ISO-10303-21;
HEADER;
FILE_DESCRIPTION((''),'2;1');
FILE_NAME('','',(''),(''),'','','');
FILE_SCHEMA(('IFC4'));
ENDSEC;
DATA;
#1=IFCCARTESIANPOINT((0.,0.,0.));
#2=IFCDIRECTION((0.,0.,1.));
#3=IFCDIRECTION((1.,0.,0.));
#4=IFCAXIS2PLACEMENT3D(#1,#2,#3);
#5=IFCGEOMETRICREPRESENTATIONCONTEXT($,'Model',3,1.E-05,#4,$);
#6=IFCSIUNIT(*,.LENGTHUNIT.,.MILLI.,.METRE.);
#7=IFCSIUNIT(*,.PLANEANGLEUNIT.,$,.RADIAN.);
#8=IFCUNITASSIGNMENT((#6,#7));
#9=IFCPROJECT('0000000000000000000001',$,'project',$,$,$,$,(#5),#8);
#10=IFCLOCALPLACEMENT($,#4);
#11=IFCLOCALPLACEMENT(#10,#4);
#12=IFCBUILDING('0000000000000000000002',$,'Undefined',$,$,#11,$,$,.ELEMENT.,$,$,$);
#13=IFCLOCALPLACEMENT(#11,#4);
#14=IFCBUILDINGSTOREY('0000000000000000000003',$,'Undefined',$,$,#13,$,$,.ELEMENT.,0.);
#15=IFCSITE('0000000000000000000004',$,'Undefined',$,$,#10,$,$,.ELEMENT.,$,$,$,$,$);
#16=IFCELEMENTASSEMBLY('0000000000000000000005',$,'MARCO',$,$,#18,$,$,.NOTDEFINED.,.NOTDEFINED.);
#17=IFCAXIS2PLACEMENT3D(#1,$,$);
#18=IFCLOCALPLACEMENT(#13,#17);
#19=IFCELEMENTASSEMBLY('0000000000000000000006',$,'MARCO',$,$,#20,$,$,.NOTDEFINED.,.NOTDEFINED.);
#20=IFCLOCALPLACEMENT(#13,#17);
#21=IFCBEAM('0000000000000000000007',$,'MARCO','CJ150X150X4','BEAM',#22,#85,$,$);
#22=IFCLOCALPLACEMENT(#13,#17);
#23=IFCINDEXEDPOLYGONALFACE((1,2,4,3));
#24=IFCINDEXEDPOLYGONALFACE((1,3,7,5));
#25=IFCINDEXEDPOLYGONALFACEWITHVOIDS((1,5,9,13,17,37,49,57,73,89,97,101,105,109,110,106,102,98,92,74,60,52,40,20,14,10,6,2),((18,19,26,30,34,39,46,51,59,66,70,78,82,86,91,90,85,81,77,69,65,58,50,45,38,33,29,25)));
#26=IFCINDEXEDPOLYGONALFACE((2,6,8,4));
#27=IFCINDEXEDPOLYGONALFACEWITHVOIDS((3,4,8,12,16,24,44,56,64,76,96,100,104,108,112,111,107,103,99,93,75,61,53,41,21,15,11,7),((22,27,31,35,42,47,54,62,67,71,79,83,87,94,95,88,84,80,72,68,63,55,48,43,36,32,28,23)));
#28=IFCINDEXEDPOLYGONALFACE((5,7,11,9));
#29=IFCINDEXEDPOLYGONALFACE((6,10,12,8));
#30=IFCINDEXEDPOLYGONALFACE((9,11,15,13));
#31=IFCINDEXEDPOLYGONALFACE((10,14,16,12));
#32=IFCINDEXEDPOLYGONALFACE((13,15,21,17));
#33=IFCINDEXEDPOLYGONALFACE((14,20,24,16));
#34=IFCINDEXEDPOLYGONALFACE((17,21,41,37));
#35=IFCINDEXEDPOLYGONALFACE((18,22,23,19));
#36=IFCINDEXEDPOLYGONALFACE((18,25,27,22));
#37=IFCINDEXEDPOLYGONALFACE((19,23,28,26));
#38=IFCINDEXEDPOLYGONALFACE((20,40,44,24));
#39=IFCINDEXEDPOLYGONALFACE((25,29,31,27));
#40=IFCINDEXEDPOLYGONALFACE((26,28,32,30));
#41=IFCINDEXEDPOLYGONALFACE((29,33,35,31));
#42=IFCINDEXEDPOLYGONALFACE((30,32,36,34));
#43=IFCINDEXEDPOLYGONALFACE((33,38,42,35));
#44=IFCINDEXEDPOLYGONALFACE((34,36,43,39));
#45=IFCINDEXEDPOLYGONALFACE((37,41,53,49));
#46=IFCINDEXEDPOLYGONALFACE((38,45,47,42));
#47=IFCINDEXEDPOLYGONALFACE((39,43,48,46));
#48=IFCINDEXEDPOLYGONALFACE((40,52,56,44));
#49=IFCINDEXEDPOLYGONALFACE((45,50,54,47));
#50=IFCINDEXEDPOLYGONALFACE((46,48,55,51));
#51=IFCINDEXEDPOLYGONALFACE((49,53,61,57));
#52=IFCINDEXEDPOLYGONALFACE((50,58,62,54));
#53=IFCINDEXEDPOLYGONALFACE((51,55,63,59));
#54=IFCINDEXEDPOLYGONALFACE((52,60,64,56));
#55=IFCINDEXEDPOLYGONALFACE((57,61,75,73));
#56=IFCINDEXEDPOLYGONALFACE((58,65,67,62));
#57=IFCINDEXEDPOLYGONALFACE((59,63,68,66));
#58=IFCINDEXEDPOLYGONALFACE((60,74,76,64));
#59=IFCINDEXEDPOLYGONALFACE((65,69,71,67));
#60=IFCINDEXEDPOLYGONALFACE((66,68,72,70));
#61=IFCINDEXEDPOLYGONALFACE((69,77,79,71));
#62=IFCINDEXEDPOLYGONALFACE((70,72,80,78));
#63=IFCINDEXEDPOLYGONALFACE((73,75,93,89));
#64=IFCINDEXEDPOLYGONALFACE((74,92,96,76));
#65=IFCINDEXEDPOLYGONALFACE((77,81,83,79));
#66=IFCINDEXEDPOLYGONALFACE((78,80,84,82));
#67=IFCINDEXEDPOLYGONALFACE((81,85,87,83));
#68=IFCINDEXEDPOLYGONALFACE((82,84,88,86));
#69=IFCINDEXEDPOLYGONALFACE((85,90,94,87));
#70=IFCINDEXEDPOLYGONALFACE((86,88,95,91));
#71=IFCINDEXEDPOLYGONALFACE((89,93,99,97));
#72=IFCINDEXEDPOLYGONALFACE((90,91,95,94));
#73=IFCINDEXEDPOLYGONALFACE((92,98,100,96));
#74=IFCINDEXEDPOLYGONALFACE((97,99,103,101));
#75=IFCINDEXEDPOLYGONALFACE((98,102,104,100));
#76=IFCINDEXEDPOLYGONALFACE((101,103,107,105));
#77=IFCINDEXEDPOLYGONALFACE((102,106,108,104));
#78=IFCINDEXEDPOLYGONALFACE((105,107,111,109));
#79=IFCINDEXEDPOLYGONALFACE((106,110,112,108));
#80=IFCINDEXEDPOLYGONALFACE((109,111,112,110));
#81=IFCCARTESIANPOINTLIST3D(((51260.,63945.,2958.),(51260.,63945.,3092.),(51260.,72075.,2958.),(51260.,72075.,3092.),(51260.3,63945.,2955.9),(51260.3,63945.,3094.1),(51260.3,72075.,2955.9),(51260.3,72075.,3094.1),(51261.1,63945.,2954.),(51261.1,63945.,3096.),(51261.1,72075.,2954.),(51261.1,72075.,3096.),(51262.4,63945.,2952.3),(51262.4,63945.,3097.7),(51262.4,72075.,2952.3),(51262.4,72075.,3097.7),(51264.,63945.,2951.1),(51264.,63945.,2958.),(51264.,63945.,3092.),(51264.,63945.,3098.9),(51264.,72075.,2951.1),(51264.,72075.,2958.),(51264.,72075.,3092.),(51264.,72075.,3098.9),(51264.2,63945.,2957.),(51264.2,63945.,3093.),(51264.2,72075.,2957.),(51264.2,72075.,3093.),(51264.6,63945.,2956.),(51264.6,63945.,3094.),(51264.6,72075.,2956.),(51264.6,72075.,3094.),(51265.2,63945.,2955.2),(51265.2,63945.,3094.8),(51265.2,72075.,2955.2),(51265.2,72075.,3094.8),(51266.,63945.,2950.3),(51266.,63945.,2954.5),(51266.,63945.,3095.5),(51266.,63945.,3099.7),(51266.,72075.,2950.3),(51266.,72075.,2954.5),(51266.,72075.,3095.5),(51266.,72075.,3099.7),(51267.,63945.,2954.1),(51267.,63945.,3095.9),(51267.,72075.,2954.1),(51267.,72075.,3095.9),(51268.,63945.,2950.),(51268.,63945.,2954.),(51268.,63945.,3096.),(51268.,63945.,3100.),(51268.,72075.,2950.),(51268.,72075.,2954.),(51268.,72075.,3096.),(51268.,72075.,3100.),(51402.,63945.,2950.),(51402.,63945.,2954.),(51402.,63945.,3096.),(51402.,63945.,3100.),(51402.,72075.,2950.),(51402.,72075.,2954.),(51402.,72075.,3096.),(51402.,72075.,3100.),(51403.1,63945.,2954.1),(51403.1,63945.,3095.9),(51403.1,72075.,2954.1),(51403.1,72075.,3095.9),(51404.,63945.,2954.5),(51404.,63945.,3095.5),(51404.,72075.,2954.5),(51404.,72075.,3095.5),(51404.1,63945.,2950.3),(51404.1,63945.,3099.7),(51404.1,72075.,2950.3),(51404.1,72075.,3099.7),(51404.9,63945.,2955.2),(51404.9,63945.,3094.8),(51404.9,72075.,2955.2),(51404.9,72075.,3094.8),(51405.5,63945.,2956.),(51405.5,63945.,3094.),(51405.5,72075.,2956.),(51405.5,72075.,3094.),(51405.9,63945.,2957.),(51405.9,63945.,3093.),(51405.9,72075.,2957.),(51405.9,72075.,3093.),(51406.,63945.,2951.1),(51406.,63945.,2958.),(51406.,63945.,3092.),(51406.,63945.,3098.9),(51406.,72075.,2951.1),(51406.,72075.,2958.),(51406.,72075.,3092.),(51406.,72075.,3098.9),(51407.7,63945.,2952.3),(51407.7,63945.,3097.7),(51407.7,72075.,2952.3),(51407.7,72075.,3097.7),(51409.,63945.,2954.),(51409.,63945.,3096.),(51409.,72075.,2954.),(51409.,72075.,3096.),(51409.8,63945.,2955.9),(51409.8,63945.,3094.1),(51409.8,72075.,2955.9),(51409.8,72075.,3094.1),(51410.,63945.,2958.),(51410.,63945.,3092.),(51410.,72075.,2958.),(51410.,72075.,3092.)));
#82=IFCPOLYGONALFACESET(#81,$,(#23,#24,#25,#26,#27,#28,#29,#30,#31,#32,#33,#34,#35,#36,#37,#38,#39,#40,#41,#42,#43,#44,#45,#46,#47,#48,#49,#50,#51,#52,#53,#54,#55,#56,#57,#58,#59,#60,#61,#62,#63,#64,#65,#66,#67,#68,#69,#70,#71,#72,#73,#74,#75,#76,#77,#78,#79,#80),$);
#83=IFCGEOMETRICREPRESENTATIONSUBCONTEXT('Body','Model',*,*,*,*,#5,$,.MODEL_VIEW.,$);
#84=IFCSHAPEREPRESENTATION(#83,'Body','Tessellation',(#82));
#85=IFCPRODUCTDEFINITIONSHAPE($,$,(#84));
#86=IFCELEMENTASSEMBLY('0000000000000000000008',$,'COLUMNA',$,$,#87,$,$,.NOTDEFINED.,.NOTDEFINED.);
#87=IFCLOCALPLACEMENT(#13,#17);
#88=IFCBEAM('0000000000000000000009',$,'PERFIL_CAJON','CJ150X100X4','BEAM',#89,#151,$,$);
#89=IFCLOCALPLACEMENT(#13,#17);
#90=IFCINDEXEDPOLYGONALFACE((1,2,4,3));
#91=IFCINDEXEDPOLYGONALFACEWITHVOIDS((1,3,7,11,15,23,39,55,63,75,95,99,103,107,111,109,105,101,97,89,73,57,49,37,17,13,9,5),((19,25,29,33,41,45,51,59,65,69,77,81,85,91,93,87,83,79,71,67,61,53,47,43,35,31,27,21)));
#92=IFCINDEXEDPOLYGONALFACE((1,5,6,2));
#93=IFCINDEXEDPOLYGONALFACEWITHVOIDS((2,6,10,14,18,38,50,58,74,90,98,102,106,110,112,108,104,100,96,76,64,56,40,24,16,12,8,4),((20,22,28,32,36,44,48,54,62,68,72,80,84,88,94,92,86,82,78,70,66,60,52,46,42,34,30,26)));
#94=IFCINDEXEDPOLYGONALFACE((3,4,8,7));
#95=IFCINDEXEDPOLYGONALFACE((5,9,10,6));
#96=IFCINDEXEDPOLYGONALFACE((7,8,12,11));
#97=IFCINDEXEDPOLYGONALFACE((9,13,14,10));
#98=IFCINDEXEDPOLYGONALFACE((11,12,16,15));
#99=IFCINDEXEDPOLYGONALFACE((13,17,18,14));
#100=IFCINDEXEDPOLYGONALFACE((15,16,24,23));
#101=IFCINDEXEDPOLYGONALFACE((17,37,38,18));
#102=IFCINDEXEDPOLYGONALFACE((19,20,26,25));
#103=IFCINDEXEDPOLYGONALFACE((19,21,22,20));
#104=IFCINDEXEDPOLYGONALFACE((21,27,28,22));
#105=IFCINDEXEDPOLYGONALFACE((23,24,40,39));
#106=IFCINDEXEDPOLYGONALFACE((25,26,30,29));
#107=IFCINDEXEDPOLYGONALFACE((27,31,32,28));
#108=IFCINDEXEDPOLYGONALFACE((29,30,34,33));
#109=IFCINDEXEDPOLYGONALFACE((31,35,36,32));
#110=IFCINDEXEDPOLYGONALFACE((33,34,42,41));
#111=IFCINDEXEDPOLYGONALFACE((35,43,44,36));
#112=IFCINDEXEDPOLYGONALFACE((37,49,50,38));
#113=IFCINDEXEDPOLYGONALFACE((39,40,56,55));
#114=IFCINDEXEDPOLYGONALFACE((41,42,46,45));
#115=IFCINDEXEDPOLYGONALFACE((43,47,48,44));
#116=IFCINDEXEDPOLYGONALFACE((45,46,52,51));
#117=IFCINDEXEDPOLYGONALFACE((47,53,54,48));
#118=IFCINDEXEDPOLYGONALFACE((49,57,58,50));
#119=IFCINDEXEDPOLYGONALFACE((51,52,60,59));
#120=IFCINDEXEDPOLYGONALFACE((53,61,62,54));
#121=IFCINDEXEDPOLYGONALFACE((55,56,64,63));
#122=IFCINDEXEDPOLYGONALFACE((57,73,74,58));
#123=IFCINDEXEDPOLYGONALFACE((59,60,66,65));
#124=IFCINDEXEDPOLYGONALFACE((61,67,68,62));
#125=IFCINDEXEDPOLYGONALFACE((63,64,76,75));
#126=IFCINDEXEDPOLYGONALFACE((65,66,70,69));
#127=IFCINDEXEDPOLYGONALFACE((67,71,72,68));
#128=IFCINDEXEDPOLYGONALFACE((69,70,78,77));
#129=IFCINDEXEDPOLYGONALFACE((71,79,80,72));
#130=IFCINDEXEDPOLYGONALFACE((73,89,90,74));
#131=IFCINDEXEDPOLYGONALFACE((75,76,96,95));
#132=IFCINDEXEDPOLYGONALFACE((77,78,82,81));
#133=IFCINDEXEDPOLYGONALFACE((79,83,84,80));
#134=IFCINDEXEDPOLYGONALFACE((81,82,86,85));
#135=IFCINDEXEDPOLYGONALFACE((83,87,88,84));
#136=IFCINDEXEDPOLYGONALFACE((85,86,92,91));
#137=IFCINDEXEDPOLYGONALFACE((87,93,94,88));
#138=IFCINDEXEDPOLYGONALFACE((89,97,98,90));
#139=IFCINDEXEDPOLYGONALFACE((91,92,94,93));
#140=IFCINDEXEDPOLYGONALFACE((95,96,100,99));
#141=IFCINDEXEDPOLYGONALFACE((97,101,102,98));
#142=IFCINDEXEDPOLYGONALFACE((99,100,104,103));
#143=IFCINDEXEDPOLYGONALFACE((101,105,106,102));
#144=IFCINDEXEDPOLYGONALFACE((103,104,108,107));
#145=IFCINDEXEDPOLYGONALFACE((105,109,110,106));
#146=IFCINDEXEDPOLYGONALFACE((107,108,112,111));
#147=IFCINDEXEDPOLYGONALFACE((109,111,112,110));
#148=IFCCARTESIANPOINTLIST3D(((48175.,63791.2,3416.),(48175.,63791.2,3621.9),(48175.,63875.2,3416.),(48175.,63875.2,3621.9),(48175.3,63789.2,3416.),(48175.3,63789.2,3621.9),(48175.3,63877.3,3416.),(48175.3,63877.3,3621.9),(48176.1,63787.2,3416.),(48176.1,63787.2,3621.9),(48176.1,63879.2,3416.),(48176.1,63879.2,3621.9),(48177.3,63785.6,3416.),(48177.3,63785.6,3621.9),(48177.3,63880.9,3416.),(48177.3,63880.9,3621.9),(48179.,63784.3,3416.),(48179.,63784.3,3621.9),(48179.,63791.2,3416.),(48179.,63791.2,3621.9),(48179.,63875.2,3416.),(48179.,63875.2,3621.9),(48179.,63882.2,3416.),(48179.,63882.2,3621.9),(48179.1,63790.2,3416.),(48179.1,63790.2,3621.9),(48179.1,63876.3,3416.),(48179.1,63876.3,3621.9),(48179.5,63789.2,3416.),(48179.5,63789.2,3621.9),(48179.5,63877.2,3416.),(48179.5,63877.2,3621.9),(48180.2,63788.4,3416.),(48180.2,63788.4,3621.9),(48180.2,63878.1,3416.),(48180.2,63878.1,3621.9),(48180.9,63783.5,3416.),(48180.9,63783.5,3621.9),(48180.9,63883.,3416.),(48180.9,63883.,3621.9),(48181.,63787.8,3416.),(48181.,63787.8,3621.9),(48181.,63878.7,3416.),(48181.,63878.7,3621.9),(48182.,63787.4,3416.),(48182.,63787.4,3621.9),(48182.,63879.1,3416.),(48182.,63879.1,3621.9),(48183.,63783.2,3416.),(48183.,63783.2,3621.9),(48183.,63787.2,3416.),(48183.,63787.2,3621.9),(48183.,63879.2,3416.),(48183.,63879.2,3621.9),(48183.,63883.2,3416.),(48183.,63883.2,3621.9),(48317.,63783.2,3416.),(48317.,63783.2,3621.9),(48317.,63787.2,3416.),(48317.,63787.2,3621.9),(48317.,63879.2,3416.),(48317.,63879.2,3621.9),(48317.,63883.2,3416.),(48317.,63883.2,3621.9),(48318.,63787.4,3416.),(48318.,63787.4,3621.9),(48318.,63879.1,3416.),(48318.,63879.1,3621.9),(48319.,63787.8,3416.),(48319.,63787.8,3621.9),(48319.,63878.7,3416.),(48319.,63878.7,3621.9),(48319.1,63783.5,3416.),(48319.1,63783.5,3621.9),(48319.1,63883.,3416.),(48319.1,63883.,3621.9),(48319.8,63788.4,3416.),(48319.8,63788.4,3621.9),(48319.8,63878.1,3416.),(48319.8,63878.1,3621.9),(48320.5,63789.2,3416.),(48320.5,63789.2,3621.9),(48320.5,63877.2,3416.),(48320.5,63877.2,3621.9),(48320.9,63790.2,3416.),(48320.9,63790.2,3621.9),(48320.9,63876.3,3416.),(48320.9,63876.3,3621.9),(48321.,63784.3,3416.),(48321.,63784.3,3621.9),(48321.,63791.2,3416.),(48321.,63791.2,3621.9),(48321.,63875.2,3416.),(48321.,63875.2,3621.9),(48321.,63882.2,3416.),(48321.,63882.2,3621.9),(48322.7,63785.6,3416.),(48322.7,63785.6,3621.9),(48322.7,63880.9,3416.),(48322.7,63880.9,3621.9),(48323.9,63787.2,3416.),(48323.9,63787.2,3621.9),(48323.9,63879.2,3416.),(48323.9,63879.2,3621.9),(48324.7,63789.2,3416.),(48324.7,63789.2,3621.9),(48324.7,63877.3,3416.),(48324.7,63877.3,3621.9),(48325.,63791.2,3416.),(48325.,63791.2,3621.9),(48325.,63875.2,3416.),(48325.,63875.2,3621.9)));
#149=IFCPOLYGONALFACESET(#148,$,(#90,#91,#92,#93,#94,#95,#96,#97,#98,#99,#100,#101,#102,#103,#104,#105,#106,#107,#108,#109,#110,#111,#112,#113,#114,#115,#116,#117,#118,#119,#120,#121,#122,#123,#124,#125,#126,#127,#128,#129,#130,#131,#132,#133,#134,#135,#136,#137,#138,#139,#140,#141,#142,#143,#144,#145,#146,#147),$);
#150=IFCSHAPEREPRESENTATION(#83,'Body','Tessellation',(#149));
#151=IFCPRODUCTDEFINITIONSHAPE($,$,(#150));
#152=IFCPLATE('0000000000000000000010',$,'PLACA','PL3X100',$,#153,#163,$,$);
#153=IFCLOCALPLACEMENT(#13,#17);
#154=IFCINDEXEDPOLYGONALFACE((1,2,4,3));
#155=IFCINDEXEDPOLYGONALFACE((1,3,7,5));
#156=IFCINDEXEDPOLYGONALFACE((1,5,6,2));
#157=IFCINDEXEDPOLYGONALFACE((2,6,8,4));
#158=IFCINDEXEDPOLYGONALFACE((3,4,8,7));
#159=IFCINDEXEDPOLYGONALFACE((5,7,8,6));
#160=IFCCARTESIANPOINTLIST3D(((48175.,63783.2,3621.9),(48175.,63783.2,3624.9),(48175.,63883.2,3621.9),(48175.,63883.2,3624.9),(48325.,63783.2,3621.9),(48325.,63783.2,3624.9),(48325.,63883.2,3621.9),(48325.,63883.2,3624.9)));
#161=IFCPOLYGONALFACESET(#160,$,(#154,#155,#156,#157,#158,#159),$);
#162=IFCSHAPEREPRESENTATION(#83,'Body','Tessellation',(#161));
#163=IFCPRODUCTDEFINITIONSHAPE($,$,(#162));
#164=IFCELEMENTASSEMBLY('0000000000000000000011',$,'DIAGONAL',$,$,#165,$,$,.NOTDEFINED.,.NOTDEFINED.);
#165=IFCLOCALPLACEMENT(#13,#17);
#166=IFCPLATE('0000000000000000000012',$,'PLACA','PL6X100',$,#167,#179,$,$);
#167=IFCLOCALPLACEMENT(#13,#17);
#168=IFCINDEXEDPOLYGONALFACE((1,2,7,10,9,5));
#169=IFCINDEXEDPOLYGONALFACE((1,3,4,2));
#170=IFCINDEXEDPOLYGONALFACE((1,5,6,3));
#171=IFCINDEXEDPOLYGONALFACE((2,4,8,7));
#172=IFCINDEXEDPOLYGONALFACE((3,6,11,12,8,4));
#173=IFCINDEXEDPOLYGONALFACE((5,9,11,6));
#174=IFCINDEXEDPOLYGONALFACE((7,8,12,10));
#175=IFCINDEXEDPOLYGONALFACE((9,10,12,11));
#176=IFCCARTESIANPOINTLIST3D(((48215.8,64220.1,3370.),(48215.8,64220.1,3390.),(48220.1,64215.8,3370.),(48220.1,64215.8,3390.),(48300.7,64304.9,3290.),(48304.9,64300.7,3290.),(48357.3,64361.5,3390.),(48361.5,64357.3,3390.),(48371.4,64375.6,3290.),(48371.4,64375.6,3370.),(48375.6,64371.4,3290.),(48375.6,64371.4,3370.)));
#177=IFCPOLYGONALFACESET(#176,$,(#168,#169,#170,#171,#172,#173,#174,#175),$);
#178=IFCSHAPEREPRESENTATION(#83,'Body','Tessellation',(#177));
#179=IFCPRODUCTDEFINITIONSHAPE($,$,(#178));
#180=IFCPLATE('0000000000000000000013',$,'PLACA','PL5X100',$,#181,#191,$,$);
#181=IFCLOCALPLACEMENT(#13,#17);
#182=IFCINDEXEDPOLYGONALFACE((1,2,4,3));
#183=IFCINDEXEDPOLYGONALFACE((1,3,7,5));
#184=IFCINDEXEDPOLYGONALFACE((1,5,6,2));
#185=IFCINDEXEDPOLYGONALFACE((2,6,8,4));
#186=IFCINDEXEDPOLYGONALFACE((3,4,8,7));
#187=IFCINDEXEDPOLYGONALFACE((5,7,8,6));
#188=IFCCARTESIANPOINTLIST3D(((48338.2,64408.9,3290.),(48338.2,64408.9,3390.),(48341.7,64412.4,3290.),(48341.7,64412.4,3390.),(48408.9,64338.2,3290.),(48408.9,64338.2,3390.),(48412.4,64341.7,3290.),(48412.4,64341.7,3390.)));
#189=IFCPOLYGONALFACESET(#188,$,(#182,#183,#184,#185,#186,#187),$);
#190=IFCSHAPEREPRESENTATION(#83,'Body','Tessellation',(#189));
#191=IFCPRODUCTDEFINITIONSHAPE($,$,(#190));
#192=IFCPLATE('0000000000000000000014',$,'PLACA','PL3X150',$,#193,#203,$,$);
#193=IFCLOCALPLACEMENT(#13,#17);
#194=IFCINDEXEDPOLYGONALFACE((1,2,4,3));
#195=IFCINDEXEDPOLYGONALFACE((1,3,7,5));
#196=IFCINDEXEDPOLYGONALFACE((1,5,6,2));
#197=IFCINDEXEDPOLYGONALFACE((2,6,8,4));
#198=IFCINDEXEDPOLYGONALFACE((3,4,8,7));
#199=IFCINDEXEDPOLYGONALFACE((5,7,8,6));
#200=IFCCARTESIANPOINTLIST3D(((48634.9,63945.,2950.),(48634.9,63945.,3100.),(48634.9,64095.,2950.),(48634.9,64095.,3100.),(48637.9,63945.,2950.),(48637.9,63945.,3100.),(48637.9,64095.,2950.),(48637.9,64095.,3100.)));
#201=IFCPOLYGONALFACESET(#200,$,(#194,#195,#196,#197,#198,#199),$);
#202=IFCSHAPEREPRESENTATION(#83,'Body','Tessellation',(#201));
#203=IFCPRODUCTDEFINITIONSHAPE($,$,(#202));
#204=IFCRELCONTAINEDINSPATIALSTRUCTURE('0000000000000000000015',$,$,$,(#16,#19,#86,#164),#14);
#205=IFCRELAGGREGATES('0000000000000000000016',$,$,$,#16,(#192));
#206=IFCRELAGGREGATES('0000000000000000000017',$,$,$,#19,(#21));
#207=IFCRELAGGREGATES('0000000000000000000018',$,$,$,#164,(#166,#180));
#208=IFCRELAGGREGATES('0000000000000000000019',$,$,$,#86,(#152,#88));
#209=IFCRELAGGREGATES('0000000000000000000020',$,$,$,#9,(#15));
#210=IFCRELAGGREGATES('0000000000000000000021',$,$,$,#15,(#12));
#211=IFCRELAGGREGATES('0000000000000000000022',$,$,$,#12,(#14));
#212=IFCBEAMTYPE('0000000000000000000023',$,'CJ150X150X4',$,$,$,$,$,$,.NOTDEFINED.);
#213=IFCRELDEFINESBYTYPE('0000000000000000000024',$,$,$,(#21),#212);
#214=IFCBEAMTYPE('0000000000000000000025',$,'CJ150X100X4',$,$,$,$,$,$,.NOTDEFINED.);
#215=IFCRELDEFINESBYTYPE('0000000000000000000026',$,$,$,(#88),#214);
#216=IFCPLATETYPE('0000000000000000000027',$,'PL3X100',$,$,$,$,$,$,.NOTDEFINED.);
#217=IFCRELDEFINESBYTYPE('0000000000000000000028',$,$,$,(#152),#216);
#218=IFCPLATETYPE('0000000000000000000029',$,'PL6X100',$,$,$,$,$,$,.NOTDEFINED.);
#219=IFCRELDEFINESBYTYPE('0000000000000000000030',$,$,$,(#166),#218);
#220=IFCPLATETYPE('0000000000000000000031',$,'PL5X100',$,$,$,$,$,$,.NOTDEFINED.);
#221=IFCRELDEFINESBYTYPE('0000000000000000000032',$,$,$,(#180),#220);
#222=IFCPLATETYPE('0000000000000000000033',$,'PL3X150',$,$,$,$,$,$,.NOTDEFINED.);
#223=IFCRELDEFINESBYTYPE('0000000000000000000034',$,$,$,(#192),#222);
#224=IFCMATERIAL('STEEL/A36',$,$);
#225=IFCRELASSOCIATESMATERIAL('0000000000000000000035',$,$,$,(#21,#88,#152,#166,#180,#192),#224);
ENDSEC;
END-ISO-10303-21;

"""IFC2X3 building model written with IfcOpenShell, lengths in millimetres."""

from ifc_helpers import new_model, si_unit, frame, origin_with_axes, origin_2d_with_axis, place, context, subcontext, project, spatial, polyline, hollow_rectangle, outline, extrude, material, type_object, element, aggregate, save


model = new_model("IFC2X3")

# Units and contexts
model_context = context("Model", 3, precision=1e-05, world=origin_with_axes())
body_context = subcontext(model_context, "Body", "Model", "MODEL_VIEW")
ifc_project = project(units=[si_unit("LENGTHUNIT", "METRE", prefix="MILLI"), si_unit("PLANEANGLEUNIT", "RADIAN")], contexts=[model_context])

# Site, building, storey
site_placement = place(None, origin_with_axes())
site = spatial("IfcSite", under=ifc_project, at=site_placement, Name="Undefined", CompositionType="ELEMENT")
building_placement = place(site_placement, origin_with_axes())
building = spatial("IfcBuilding", under=site, at=building_placement, Name="Undefined", CompositionType="ELEMENT")
storey_placement = place(building_placement, origin_with_axes())
storey = spatial("IfcBuildingStorey", under=building, at=storey_placement, Name="Undefined", CompositionType="ELEMENT", Elevation=0.0)

# Element assembly
assembly_1_placement = place(storey_placement, origin_with_axes())
assembly_1 = element("IfcElementAssembly", 1, at=assembly_1_placement, inside=storey, Name="MARCO", AssemblyPlace="NOTDEFINED", PredefinedType="NOTDEFINED")
ifc_material_1 = material(Name="STEEL/A36")
beam_type_1 = type_object("IfcBeamType", Name="CJ150X150X4", PredefinedType="NOTDEFINED")

# Element assemblies, beams
assembly_2_placement = place(storey_placement, origin_with_axes())
assembly_2 = element("IfcElementAssembly", 2, at=assembly_2_placement, inside=storey, Name="MARCO", AssemblyPlace="NOTDEFINED", PredefinedType="NOTDEFINED")
beam_1_placement = place(assembly_2_placement, frame((51335.0, 63945.0, 3025.0), z_axis=(0.0, 0.0, 1.0), x_axis=(0.0, 1.0, 0.0)))
beam_1 = element("IfcBeam", 3, at=beam_1_placement, type_object=beam_type_1, material=ifc_material_1, Name="MARCO", Description="CJ150X150X4", ObjectType="BEAM", context=body_context, shape_type="SweptSolid", body=[
    extrude(hollow_rectangle(XDim=150.0, YDim=150.0, WallThickness=4.0, InnerFilletRadius=4.0, OuterFilletRadius=8.0, at=origin_2d_with_axis()), frame((8130.0, 0.0, 0.0), z_axis=(-1.0, 0.0, 0.0), x_axis=(0.0, -1.0, 0.0)), (0.0, 0.0, 1.0), 8130.0),
])
beam_type_2 = type_object("IfcBeamType", Name="CJ150X100X4", PredefinedType="NOTDEFINED")
assembly_3_placement = place(storey_placement, origin_with_axes())
assembly_3 = element("IfcElementAssembly", 4, at=assembly_3_placement, inside=storey, Name="COLUMNA", AssemblyPlace="NOTDEFINED", PredefinedType="NOTDEFINED")
beam_2_placement = place(assembly_3_placement, frame((48250.0, 63833.2, 3621.9), z_axis=(-1.0, 0.0, 0.0), x_axis=(0.0, 0.0, -1.0)))
beam_2 = element("IfcBeam", 5, at=beam_2_placement, type_object=beam_type_2, material=ifc_material_1, Name="PERFIL_CAJON", Description="CJ150X100X4", ObjectType="BEAM", context=body_context, shape_type="SweptSolid", body=[
    extrude(hollow_rectangle(XDim=100.0, YDim=150.0, WallThickness=4.0, InnerFilletRadius=4.0, OuterFilletRadius=8.0, at=origin_2d_with_axis()), frame((205.9, 0.0, 0.0), z_axis=(-1.0, 0.0, 0.0), x_axis=(0.0, -1.0, 0.0)), (0.0, 0.0, 1.0), 205.9),
])

# Plate
plate_type_1 = type_object("IfcPlateType", Name="PL3X100", PredefinedType="NOTDEFINED")
plate_1_placement = place(assembly_3_placement, frame((48325.0, 63883.2, 3623.4), z_axis=(0.0, 0.0, -1.0), x_axis=(0.0, -1.0, 0.0)))
plate_1 = element("IfcPlate", 6, at=plate_1_placement, type_object=plate_type_1, material=ifc_material_1, Name="PLACA", Description="PL3X100", context=body_context, shape_type="SweptSolid", body=[
    extrude(outline(polyline([(0.0, 0.0), (100.0, 0.0), (100.0, 150.0), (0.0, 150.0), (0.0, 0.0)])), frame((0.0, 0.0, -1.5), z_axis=(0.0, 0.0, 1.0), x_axis=(1.0, 0.0, 0.0)), (0.0, 0.0, 1.0), 3.0),
])

# Element assembly, plates
assembly_4_placement = place(storey_placement, origin_with_axes())
assembly_4 = element("IfcElementAssembly", 7, at=assembly_4_placement, inside=storey, Name="DIAGONAL", AssemblyPlace="NOTDEFINED", PredefinedType="NOTDEFINED")
plate_type_2 = type_object("IfcPlateType", Name="PL6X100", PredefinedType="NOTDEFINED")
plate_2_placement = place(assembly_4_placement, frame((48218.0, 64218.0, 3290.0), z_axis=(0.707107, -0.707107, 0.0), x_axis=(0.707107, 0.707107, 0.0)))
plate_2 = element("IfcPlate", 8, at=plate_2_placement, type_object=plate_type_2, material=ifc_material_1, Name="PLACA", Description="PL6X100", context=body_context, shape_type="SweptSolid", body=[
    extrude(outline(polyline([(0.0, 80.0), (120.0, 0.0), (220.0, 0.0), (220.0, 80.0), (200.0, 100.0), (0.0, 100.0), (0.0, 80.0)])), frame((0.0, 0.0, -3.0), z_axis=(0.0, 0.0, 1.0), x_axis=(1.0, 0.0, 0.0)), (0.0, 0.0, 1.0), 6.0),
])
plate_type_3 = type_object("IfcPlateType", Name="PL5X100", PredefinedType="NOTDEFINED")
plate_3_placement = place(assembly_4_placement, frame((48410.6, 64339.9, 3390.0), z_axis=(0.707107, 0.707107, 0.0), x_axis=(0.0, 0.0, -1.0)))
plate_3 = element("IfcPlate", 9, at=plate_3_placement, type_object=plate_type_3, material=ifc_material_1, Name="PLACA", Description="PL5X100", context=body_context, shape_type="SweptSolid", body=[
    extrude(outline(polyline([(0.0, 0.0), (100.0, 0.0), (100.0, 100.0), (0.0, 100.0), (0.0, 0.0)])), frame((0.0, 0.0, -2.5), z_axis=(0.0, 0.0, 1.0), x_axis=(1.0, 0.0, 0.0)), (0.0, 0.0, 1.0), 5.0),
])

# Plate
plate_type_4 = type_object("IfcPlateType", Name="PL3X150", PredefinedType="NOTDEFINED")
plate_4_placement = place(assembly_1_placement, frame((48636.4, 63945.0, 2950.0), z_axis=(1.0, 0.0, 0.0), x_axis=(0.0, 1.0, 0.0)))
plate_4 = element("IfcPlate", 10, at=plate_4_placement, type_object=plate_type_4, material=ifc_material_1, Name="PLACA", Description="PL3X150", context=body_context, shape_type="SweptSolid", body=[
    extrude(outline(polyline([(0.0, 0.0), (150.0, 0.0), (150.0, 150.0), (0.0, 150.0), (0.0, 0.0)])), frame((0.0, 0.0, -1.5), z_axis=(0.0, 0.0, 1.0), x_axis=(1.0, 0.0, 0.0)), (0.0, 0.0, 1.0), 3.0),
])
aggregate(assembly_1, [plate_4])
aggregate(assembly_2, [beam_1])

aggregate(assembly_4, [plate_2, plate_3])
aggregate(assembly_3, [plate_1, beam_2])

save(model, "model.ifc")
